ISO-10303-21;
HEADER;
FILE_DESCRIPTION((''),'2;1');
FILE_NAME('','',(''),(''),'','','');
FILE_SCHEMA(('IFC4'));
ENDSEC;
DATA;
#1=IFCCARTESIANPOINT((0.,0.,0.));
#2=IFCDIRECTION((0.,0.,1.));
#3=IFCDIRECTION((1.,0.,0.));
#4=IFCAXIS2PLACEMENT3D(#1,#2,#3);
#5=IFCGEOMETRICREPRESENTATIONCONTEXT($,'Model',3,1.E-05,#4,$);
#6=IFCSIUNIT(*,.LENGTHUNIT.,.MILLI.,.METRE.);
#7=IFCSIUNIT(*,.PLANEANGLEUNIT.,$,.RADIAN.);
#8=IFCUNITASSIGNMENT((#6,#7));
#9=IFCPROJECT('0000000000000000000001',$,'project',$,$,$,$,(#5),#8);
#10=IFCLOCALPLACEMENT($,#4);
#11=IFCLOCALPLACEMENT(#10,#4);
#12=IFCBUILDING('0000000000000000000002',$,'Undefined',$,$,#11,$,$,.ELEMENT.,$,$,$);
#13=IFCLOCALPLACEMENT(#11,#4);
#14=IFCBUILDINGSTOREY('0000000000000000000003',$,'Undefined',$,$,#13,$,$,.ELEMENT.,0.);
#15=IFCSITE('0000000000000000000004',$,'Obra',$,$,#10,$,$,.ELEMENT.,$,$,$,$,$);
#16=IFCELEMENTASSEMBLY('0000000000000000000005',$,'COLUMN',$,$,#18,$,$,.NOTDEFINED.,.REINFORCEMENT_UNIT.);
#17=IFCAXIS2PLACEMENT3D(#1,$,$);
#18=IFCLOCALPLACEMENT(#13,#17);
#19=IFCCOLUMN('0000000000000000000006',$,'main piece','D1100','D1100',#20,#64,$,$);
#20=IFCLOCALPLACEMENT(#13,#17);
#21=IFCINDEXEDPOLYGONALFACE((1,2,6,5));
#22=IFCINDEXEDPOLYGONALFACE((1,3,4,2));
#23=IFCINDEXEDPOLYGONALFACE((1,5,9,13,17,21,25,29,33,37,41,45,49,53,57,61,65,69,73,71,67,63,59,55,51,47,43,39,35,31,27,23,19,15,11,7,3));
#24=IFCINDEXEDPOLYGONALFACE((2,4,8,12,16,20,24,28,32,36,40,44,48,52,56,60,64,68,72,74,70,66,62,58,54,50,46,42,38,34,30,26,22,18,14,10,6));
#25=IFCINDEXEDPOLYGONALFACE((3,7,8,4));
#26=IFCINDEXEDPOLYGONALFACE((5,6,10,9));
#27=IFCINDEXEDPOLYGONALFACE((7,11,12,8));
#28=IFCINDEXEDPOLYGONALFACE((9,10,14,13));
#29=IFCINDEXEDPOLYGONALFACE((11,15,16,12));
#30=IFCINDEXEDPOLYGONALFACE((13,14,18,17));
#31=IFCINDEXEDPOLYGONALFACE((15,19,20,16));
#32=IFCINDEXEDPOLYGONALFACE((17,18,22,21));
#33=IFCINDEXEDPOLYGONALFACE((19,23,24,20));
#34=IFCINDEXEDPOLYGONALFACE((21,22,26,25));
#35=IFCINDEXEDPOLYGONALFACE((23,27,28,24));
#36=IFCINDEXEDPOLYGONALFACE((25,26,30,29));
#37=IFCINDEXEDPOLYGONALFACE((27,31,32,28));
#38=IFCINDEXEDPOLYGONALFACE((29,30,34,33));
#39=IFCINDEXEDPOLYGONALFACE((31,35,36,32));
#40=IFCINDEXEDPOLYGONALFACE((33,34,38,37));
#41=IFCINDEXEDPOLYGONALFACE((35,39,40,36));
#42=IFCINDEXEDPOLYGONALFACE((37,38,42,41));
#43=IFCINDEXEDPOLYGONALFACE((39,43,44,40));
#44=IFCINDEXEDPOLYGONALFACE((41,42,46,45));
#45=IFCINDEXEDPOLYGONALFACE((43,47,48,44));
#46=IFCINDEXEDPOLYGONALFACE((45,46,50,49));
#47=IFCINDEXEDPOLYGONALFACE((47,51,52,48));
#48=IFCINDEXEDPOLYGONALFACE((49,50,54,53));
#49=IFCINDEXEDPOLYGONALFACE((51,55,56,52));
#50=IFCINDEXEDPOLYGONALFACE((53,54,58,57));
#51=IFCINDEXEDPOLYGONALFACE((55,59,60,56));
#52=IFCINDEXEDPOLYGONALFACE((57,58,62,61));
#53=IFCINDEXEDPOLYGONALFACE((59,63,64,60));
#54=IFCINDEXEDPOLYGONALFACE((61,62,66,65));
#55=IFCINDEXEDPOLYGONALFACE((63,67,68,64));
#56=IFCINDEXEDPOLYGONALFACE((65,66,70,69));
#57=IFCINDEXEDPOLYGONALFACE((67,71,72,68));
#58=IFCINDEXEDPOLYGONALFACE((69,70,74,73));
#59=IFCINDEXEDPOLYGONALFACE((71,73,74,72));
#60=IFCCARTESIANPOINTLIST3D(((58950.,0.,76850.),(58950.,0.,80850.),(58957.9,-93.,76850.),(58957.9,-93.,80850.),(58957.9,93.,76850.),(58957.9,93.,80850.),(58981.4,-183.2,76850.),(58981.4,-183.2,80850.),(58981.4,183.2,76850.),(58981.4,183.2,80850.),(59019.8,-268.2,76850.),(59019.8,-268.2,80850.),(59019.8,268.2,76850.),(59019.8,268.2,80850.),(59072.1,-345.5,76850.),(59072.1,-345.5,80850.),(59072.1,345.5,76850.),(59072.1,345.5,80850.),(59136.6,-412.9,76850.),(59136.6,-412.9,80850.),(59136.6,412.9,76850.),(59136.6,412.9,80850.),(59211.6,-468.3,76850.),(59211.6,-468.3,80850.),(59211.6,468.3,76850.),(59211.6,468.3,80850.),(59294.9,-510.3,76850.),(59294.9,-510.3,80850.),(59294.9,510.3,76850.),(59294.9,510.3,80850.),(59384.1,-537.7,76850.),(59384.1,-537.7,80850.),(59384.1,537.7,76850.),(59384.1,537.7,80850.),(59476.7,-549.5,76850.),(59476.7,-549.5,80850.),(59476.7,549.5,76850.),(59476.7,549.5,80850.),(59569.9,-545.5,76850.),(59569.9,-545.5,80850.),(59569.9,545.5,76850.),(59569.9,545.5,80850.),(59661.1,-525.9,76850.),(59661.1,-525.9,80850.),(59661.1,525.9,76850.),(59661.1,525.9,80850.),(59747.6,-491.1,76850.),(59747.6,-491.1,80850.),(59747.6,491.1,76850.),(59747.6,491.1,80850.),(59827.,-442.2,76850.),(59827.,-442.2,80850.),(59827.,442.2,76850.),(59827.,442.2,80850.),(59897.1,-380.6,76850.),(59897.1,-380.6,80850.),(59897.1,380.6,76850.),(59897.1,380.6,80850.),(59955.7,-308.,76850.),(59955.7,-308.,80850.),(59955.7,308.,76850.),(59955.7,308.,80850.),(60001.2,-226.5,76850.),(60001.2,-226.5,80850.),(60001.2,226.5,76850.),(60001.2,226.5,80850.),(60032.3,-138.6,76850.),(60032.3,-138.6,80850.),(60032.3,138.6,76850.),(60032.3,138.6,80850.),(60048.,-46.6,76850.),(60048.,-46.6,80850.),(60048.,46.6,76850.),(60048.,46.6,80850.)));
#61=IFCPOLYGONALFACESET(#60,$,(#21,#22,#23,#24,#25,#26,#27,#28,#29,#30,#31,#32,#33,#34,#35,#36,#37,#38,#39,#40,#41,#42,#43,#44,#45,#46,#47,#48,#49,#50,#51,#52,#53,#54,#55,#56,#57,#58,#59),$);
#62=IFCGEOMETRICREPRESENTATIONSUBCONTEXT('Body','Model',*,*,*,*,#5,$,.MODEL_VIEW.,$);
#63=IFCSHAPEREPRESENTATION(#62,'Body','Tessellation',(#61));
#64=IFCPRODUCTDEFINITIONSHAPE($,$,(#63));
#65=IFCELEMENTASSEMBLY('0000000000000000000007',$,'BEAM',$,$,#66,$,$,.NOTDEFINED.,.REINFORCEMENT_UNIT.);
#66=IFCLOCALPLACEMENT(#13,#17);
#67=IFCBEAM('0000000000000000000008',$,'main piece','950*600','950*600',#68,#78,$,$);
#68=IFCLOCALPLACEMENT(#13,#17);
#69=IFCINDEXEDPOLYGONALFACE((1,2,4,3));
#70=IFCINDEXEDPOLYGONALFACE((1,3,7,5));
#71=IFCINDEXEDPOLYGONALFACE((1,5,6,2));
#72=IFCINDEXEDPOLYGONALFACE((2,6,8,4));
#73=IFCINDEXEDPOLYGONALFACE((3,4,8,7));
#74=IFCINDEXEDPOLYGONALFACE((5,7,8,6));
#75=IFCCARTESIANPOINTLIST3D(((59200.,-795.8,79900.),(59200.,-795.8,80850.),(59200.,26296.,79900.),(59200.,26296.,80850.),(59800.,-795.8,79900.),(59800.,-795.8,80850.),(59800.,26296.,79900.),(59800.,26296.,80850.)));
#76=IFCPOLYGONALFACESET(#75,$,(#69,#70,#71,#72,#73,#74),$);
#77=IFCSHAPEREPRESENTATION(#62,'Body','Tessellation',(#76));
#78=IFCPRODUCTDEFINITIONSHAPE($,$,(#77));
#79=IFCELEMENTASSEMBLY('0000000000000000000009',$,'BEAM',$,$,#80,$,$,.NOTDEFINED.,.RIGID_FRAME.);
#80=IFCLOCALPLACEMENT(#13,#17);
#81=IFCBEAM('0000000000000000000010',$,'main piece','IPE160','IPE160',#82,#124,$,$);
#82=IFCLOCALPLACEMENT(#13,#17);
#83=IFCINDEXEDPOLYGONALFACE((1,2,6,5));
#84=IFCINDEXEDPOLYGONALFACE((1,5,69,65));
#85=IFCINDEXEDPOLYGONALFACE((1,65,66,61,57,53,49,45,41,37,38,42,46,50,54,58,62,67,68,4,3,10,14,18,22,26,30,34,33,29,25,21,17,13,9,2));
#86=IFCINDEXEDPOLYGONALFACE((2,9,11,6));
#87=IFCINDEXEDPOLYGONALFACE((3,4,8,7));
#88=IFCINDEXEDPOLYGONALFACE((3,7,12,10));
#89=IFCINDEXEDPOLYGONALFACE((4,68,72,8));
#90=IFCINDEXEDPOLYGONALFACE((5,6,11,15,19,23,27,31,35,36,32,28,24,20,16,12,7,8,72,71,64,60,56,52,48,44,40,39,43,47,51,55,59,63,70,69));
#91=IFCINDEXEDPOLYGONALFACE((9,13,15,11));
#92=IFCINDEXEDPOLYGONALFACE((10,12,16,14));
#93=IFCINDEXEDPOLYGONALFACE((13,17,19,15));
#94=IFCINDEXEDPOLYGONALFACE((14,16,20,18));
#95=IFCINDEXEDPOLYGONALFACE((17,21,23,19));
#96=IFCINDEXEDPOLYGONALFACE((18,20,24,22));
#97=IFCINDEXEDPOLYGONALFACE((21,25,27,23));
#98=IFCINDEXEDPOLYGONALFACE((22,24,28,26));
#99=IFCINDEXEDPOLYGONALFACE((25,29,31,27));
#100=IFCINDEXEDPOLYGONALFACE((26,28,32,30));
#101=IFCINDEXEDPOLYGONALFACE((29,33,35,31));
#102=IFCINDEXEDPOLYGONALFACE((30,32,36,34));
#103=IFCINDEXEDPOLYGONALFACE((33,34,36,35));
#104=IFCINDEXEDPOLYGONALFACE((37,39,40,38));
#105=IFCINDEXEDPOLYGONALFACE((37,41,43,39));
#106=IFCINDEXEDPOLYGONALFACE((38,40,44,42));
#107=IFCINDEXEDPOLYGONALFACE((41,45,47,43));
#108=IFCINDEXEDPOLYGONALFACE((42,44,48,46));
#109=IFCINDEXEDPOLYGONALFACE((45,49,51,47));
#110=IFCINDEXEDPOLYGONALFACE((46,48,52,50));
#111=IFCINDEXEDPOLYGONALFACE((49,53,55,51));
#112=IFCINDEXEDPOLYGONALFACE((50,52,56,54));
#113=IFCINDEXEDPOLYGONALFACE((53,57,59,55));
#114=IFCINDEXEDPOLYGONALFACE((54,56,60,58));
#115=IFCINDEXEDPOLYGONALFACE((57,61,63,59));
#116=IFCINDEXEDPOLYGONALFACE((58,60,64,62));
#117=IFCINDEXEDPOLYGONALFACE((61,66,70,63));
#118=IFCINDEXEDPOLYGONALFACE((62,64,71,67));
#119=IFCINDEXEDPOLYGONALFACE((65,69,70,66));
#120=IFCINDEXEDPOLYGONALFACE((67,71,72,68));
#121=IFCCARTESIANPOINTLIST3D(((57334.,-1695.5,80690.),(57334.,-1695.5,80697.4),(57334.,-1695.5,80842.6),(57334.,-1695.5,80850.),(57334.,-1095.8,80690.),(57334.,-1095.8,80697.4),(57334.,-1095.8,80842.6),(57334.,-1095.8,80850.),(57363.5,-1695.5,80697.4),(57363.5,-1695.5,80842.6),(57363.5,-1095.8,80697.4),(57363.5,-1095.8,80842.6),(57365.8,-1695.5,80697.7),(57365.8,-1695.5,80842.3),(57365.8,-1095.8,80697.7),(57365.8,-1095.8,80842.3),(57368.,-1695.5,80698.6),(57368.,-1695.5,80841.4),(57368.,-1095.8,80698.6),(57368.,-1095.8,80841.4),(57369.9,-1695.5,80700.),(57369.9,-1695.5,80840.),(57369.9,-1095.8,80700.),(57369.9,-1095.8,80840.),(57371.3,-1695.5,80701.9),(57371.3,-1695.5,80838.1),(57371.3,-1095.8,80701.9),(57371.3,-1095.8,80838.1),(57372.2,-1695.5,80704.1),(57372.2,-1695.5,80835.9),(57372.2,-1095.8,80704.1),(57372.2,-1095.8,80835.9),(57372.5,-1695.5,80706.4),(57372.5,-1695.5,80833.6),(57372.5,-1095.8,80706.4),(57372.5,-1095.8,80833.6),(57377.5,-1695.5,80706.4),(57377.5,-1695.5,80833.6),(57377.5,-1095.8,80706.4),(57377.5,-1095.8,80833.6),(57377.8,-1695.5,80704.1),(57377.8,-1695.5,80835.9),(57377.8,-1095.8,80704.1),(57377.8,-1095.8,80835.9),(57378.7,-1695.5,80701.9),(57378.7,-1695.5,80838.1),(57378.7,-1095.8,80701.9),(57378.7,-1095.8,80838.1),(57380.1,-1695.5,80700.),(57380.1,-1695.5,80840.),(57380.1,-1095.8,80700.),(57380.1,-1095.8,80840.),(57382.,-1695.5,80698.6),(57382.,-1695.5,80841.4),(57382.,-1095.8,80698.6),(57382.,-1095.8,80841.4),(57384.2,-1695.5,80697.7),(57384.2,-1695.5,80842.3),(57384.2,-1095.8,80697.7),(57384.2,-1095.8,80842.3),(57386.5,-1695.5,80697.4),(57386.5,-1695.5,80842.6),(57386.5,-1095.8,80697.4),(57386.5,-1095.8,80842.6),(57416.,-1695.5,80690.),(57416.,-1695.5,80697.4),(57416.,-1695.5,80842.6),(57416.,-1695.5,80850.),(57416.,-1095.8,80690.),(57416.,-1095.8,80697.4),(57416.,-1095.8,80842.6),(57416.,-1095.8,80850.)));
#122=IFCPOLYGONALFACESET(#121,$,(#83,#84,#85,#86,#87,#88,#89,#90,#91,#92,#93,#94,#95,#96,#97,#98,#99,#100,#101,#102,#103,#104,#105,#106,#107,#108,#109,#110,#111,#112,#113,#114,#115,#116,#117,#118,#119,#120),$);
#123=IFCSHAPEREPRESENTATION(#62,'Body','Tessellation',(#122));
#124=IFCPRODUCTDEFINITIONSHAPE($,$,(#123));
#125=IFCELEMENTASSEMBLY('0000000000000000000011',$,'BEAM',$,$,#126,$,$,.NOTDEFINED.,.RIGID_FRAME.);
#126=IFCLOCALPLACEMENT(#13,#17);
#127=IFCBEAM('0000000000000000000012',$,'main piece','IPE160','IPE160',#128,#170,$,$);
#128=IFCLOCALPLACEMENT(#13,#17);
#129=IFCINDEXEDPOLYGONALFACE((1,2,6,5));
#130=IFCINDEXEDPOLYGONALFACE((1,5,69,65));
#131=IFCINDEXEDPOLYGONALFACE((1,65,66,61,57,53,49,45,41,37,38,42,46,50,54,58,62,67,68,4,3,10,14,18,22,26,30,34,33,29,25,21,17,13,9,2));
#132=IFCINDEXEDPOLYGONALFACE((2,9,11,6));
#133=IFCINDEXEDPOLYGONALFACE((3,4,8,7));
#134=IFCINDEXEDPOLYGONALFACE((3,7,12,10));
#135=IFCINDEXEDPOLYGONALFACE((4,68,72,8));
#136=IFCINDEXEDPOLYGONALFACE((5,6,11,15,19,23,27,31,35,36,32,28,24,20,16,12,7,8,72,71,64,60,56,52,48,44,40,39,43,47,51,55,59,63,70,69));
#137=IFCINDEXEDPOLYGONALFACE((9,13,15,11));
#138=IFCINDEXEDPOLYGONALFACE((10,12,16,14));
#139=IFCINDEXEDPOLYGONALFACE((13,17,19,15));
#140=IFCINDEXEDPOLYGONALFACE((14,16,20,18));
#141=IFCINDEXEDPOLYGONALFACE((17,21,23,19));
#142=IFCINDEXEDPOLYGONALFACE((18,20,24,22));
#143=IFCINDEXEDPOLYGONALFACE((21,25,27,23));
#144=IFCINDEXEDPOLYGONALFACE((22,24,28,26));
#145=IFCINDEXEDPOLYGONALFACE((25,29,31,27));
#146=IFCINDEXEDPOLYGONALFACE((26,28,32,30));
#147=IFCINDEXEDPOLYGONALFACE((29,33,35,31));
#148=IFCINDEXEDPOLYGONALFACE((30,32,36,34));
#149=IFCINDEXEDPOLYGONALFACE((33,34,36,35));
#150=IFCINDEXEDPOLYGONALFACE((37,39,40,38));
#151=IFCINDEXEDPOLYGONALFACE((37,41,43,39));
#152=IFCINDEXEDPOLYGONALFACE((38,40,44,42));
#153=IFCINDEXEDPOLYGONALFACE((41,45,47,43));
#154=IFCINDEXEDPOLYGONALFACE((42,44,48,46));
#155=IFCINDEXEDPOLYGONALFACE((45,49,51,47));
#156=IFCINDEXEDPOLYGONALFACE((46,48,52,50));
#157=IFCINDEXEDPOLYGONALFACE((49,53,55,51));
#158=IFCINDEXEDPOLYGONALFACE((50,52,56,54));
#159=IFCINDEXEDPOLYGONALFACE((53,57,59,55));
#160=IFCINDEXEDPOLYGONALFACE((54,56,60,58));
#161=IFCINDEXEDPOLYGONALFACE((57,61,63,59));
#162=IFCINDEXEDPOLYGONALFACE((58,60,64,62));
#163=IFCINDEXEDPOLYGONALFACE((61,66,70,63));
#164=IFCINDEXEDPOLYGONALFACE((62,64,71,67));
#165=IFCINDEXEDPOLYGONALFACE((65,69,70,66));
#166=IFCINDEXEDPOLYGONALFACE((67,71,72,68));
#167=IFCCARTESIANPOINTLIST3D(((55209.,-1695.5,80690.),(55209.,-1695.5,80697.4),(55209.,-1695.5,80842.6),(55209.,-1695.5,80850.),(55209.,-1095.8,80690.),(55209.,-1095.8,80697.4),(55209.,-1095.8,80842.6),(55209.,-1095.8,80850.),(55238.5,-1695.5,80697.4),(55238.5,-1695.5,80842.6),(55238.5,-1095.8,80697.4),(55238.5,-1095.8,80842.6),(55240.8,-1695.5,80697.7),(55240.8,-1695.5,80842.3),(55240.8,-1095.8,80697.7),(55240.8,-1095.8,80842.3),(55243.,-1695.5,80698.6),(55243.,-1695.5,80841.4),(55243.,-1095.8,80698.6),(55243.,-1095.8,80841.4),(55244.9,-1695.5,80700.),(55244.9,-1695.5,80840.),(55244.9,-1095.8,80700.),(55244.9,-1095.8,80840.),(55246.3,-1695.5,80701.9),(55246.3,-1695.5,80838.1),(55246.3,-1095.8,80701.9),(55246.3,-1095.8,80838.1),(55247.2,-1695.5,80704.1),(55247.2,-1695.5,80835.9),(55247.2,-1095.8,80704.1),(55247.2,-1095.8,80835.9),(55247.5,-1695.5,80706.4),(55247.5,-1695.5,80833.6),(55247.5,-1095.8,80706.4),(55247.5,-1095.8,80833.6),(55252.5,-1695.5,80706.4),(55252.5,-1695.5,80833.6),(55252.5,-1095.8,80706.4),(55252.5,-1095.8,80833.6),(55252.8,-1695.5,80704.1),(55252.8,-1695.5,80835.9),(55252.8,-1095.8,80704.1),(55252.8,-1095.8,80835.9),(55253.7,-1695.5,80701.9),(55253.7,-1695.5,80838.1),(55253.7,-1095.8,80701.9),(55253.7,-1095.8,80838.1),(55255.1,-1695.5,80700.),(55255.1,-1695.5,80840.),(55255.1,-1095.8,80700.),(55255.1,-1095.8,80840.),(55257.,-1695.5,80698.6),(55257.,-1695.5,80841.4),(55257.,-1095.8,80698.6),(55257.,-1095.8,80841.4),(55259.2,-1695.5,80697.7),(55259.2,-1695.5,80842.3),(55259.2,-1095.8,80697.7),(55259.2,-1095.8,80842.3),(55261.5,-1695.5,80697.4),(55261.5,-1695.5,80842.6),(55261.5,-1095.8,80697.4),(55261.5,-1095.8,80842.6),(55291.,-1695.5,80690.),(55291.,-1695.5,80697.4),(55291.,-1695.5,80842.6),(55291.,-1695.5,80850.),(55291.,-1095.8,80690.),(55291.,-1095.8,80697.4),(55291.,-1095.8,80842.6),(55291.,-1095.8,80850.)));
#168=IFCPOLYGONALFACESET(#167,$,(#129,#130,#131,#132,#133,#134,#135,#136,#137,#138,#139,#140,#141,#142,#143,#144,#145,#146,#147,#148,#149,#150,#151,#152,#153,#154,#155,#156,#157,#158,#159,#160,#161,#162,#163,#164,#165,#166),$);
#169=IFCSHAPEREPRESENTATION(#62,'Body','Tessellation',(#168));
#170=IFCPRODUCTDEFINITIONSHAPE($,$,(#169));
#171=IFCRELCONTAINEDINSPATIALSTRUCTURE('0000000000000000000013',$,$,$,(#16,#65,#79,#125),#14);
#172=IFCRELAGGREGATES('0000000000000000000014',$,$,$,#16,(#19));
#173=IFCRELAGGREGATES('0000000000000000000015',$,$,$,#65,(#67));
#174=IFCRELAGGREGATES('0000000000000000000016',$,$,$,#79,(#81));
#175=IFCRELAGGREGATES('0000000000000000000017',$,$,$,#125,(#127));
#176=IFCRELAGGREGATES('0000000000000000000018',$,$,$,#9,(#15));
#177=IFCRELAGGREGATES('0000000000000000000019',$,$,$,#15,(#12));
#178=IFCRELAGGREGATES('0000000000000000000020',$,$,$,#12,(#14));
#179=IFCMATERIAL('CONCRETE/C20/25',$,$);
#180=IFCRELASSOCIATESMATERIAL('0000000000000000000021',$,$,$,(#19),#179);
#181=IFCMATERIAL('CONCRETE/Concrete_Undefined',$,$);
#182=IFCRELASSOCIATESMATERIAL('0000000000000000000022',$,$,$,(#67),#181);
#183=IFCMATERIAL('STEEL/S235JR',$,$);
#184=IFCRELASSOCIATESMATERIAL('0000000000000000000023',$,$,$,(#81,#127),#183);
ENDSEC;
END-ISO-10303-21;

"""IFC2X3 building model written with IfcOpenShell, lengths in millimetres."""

from ifc_helpers import new_model, si_unit, frame, origin_with_axes, origin_2d_with_axis, place, context, subcontext, project, spatial, rectangle, circle, i_section, extrude, material, element, aggregate, save


model = new_model("IFC2X3")

# Units and contexts
model_context = context("Model", 3, precision=1e-05, world=origin_with_axes())
body_context = subcontext(model_context, "Body", "Model", "MODEL_VIEW")
ifc_project = project(units=[si_unit("LENGTHUNIT", "METRE", prefix="MILLI"), si_unit("PLANEANGLEUNIT", "RADIAN")], contexts=[model_context])

# Site, building, storey
site_placement = place(None, origin_with_axes())
site = spatial("IfcSite", under=ifc_project, at=site_placement, Name="Obra", CompositionType="ELEMENT")
building_placement = place(site_placement, origin_with_axes())
building = spatial("IfcBuilding", under=site, at=building_placement, Name="Undefined", CompositionType="ELEMENT")
storey_placement = place(building_placement, origin_with_axes())
storey = spatial("IfcBuildingStorey", under=building, at=storey_placement, Name="Undefined", CompositionType="ELEMENT", Elevation=0.0)

# Element assembly, column
assembly_1_placement = place(storey_placement, origin_with_axes())
assembly_1 = element("IfcElementAssembly", 1, at=assembly_1_placement, inside=storey, Name="COLUMN", AssemblyPlace="NOTDEFINED", PredefinedType="REINFORCEMENT_UNIT")
ifc_material_1 = material(Name="CONCRETE/C20/25")
column_placement = place(assembly_1_placement, frame((59500.0, 0.0, 76850.0), z_axis=(0.0, 0.0, 1.0), x_axis=(0.0, 1.0, 0.0)))
column = element("IfcColumn", 2, at=column_placement, material=ifc_material_1, Name="main piece", Description="D1100", ObjectType="D1100", context=body_context, shape_type="SweptSolid", body=[
    extrude(circle(Radius=550.0, at=origin_2d_with_axis()), frame((0.0, 0.0, 4000.0), z_axis=(0.0, 0.0, -1.0), x_axis=(0.0, 1.0, 0.0)), (0.0, 0.0, 1.0), 4000.0),
])
aggregate(assembly_1, [column])

# Element assemblies, beams
assembly_2_placement = place(storey_placement, origin_with_axes())
assembly_2 = element("IfcElementAssembly", 3, at=assembly_2_placement, inside=storey, Name="BEAM", AssemblyPlace="NOTDEFINED", PredefinedType="REINFORCEMENT_UNIT")
ifc_material_2 = material(Name="CONCRETE/Concrete_Undefined")
beam_1_placement = place(assembly_2_placement, frame((59500.0, -795.8, 80375.0), z_axis=(0.0, 0.0, 1.0), x_axis=(0.0, 1.0, 0.0)))
beam_1 = element("IfcBeam", 4, at=beam_1_placement, material=ifc_material_2, Name="main piece", Description="950*600", ObjectType="950*600", context=body_context, shape_type="SweptSolid", body=[
    extrude(rectangle(XDim=600.0, YDim=950.0, at=origin_2d_with_axis()), frame((27091.8, 0.0, 0.0), z_axis=(-1.0, 0.0, 0.0), x_axis=(0.0, -1.0, 0.0)), (0.0, 0.0, 1.0), 27091.8),
])
aggregate(assembly_2, [beam_1])
assembly_3_placement = place(storey_placement, origin_with_axes())
assembly_3 = element("IfcElementAssembly", 5, at=assembly_3_placement, inside=storey, Name="BEAM", AssemblyPlace="NOTDEFINED", PredefinedType="RIGID_FRAME")
ifc_material_3 = material(Name="STEEL/S235JR")
beam_2_placement = place(assembly_3_placement, frame((57375.0, -1095.8, 80770.0), z_axis=(0.0, 0.0, 1.0), x_axis=(0.0, -1.0, 0.0)))
beam_2 = element("IfcBeam", 6, at=beam_2_placement, material=ifc_material_3, Name="main piece", Description="IPE160", ObjectType="IPE160", context=body_context, shape_type="SweptSolid", body=[
    extrude(i_section(OverallWidth=82.0, OverallDepth=160.0, WebThickness=5.0, FlangeThickness=7.4, FilletRadius=9.0, at=origin_2d_with_axis()), frame((599.7, 0.0, 0.0), z_axis=(-1.0, 0.0, 0.0), x_axis=(0.0, -1.0, 0.0)), (0.0, 0.0, 1.0), 599.7),
])
aggregate(assembly_3, [beam_2])
assembly_4_placement = place(storey_placement, origin_with_axes())
assembly_4 = element("IfcElementAssembly", 7, at=assembly_4_placement, inside=storey, Name="BEAM", AssemblyPlace="NOTDEFINED", PredefinedType="RIGID_FRAME")
beam_3_placement = place(assembly_4_placement, frame((55250.0, -1095.8, 80770.0), z_axis=(0.0, 0.0, 1.0), x_axis=(0.0, -1.0, 0.0)))
beam_3 = element("IfcBeam", 8, at=beam_3_placement, material=ifc_material_3, Name="main piece", Description="IPE160", ObjectType="IPE160", context=body_context, shape_type="SweptSolid", body=[
    extrude(i_section(OverallWidth=82.0, OverallDepth=160.0, WebThickness=5.0, FlangeThickness=7.4, FilletRadius=9.0, at=origin_2d_with_axis()), frame((599.7, 0.0, 0.0), z_axis=(-1.0, 0.0, 0.0), x_axis=(0.0, -1.0, 0.0)), (0.0, 0.0, 1.0), 599.7),
])
aggregate(assembly_4, [beam_3])

save(model, "model.ifc")
